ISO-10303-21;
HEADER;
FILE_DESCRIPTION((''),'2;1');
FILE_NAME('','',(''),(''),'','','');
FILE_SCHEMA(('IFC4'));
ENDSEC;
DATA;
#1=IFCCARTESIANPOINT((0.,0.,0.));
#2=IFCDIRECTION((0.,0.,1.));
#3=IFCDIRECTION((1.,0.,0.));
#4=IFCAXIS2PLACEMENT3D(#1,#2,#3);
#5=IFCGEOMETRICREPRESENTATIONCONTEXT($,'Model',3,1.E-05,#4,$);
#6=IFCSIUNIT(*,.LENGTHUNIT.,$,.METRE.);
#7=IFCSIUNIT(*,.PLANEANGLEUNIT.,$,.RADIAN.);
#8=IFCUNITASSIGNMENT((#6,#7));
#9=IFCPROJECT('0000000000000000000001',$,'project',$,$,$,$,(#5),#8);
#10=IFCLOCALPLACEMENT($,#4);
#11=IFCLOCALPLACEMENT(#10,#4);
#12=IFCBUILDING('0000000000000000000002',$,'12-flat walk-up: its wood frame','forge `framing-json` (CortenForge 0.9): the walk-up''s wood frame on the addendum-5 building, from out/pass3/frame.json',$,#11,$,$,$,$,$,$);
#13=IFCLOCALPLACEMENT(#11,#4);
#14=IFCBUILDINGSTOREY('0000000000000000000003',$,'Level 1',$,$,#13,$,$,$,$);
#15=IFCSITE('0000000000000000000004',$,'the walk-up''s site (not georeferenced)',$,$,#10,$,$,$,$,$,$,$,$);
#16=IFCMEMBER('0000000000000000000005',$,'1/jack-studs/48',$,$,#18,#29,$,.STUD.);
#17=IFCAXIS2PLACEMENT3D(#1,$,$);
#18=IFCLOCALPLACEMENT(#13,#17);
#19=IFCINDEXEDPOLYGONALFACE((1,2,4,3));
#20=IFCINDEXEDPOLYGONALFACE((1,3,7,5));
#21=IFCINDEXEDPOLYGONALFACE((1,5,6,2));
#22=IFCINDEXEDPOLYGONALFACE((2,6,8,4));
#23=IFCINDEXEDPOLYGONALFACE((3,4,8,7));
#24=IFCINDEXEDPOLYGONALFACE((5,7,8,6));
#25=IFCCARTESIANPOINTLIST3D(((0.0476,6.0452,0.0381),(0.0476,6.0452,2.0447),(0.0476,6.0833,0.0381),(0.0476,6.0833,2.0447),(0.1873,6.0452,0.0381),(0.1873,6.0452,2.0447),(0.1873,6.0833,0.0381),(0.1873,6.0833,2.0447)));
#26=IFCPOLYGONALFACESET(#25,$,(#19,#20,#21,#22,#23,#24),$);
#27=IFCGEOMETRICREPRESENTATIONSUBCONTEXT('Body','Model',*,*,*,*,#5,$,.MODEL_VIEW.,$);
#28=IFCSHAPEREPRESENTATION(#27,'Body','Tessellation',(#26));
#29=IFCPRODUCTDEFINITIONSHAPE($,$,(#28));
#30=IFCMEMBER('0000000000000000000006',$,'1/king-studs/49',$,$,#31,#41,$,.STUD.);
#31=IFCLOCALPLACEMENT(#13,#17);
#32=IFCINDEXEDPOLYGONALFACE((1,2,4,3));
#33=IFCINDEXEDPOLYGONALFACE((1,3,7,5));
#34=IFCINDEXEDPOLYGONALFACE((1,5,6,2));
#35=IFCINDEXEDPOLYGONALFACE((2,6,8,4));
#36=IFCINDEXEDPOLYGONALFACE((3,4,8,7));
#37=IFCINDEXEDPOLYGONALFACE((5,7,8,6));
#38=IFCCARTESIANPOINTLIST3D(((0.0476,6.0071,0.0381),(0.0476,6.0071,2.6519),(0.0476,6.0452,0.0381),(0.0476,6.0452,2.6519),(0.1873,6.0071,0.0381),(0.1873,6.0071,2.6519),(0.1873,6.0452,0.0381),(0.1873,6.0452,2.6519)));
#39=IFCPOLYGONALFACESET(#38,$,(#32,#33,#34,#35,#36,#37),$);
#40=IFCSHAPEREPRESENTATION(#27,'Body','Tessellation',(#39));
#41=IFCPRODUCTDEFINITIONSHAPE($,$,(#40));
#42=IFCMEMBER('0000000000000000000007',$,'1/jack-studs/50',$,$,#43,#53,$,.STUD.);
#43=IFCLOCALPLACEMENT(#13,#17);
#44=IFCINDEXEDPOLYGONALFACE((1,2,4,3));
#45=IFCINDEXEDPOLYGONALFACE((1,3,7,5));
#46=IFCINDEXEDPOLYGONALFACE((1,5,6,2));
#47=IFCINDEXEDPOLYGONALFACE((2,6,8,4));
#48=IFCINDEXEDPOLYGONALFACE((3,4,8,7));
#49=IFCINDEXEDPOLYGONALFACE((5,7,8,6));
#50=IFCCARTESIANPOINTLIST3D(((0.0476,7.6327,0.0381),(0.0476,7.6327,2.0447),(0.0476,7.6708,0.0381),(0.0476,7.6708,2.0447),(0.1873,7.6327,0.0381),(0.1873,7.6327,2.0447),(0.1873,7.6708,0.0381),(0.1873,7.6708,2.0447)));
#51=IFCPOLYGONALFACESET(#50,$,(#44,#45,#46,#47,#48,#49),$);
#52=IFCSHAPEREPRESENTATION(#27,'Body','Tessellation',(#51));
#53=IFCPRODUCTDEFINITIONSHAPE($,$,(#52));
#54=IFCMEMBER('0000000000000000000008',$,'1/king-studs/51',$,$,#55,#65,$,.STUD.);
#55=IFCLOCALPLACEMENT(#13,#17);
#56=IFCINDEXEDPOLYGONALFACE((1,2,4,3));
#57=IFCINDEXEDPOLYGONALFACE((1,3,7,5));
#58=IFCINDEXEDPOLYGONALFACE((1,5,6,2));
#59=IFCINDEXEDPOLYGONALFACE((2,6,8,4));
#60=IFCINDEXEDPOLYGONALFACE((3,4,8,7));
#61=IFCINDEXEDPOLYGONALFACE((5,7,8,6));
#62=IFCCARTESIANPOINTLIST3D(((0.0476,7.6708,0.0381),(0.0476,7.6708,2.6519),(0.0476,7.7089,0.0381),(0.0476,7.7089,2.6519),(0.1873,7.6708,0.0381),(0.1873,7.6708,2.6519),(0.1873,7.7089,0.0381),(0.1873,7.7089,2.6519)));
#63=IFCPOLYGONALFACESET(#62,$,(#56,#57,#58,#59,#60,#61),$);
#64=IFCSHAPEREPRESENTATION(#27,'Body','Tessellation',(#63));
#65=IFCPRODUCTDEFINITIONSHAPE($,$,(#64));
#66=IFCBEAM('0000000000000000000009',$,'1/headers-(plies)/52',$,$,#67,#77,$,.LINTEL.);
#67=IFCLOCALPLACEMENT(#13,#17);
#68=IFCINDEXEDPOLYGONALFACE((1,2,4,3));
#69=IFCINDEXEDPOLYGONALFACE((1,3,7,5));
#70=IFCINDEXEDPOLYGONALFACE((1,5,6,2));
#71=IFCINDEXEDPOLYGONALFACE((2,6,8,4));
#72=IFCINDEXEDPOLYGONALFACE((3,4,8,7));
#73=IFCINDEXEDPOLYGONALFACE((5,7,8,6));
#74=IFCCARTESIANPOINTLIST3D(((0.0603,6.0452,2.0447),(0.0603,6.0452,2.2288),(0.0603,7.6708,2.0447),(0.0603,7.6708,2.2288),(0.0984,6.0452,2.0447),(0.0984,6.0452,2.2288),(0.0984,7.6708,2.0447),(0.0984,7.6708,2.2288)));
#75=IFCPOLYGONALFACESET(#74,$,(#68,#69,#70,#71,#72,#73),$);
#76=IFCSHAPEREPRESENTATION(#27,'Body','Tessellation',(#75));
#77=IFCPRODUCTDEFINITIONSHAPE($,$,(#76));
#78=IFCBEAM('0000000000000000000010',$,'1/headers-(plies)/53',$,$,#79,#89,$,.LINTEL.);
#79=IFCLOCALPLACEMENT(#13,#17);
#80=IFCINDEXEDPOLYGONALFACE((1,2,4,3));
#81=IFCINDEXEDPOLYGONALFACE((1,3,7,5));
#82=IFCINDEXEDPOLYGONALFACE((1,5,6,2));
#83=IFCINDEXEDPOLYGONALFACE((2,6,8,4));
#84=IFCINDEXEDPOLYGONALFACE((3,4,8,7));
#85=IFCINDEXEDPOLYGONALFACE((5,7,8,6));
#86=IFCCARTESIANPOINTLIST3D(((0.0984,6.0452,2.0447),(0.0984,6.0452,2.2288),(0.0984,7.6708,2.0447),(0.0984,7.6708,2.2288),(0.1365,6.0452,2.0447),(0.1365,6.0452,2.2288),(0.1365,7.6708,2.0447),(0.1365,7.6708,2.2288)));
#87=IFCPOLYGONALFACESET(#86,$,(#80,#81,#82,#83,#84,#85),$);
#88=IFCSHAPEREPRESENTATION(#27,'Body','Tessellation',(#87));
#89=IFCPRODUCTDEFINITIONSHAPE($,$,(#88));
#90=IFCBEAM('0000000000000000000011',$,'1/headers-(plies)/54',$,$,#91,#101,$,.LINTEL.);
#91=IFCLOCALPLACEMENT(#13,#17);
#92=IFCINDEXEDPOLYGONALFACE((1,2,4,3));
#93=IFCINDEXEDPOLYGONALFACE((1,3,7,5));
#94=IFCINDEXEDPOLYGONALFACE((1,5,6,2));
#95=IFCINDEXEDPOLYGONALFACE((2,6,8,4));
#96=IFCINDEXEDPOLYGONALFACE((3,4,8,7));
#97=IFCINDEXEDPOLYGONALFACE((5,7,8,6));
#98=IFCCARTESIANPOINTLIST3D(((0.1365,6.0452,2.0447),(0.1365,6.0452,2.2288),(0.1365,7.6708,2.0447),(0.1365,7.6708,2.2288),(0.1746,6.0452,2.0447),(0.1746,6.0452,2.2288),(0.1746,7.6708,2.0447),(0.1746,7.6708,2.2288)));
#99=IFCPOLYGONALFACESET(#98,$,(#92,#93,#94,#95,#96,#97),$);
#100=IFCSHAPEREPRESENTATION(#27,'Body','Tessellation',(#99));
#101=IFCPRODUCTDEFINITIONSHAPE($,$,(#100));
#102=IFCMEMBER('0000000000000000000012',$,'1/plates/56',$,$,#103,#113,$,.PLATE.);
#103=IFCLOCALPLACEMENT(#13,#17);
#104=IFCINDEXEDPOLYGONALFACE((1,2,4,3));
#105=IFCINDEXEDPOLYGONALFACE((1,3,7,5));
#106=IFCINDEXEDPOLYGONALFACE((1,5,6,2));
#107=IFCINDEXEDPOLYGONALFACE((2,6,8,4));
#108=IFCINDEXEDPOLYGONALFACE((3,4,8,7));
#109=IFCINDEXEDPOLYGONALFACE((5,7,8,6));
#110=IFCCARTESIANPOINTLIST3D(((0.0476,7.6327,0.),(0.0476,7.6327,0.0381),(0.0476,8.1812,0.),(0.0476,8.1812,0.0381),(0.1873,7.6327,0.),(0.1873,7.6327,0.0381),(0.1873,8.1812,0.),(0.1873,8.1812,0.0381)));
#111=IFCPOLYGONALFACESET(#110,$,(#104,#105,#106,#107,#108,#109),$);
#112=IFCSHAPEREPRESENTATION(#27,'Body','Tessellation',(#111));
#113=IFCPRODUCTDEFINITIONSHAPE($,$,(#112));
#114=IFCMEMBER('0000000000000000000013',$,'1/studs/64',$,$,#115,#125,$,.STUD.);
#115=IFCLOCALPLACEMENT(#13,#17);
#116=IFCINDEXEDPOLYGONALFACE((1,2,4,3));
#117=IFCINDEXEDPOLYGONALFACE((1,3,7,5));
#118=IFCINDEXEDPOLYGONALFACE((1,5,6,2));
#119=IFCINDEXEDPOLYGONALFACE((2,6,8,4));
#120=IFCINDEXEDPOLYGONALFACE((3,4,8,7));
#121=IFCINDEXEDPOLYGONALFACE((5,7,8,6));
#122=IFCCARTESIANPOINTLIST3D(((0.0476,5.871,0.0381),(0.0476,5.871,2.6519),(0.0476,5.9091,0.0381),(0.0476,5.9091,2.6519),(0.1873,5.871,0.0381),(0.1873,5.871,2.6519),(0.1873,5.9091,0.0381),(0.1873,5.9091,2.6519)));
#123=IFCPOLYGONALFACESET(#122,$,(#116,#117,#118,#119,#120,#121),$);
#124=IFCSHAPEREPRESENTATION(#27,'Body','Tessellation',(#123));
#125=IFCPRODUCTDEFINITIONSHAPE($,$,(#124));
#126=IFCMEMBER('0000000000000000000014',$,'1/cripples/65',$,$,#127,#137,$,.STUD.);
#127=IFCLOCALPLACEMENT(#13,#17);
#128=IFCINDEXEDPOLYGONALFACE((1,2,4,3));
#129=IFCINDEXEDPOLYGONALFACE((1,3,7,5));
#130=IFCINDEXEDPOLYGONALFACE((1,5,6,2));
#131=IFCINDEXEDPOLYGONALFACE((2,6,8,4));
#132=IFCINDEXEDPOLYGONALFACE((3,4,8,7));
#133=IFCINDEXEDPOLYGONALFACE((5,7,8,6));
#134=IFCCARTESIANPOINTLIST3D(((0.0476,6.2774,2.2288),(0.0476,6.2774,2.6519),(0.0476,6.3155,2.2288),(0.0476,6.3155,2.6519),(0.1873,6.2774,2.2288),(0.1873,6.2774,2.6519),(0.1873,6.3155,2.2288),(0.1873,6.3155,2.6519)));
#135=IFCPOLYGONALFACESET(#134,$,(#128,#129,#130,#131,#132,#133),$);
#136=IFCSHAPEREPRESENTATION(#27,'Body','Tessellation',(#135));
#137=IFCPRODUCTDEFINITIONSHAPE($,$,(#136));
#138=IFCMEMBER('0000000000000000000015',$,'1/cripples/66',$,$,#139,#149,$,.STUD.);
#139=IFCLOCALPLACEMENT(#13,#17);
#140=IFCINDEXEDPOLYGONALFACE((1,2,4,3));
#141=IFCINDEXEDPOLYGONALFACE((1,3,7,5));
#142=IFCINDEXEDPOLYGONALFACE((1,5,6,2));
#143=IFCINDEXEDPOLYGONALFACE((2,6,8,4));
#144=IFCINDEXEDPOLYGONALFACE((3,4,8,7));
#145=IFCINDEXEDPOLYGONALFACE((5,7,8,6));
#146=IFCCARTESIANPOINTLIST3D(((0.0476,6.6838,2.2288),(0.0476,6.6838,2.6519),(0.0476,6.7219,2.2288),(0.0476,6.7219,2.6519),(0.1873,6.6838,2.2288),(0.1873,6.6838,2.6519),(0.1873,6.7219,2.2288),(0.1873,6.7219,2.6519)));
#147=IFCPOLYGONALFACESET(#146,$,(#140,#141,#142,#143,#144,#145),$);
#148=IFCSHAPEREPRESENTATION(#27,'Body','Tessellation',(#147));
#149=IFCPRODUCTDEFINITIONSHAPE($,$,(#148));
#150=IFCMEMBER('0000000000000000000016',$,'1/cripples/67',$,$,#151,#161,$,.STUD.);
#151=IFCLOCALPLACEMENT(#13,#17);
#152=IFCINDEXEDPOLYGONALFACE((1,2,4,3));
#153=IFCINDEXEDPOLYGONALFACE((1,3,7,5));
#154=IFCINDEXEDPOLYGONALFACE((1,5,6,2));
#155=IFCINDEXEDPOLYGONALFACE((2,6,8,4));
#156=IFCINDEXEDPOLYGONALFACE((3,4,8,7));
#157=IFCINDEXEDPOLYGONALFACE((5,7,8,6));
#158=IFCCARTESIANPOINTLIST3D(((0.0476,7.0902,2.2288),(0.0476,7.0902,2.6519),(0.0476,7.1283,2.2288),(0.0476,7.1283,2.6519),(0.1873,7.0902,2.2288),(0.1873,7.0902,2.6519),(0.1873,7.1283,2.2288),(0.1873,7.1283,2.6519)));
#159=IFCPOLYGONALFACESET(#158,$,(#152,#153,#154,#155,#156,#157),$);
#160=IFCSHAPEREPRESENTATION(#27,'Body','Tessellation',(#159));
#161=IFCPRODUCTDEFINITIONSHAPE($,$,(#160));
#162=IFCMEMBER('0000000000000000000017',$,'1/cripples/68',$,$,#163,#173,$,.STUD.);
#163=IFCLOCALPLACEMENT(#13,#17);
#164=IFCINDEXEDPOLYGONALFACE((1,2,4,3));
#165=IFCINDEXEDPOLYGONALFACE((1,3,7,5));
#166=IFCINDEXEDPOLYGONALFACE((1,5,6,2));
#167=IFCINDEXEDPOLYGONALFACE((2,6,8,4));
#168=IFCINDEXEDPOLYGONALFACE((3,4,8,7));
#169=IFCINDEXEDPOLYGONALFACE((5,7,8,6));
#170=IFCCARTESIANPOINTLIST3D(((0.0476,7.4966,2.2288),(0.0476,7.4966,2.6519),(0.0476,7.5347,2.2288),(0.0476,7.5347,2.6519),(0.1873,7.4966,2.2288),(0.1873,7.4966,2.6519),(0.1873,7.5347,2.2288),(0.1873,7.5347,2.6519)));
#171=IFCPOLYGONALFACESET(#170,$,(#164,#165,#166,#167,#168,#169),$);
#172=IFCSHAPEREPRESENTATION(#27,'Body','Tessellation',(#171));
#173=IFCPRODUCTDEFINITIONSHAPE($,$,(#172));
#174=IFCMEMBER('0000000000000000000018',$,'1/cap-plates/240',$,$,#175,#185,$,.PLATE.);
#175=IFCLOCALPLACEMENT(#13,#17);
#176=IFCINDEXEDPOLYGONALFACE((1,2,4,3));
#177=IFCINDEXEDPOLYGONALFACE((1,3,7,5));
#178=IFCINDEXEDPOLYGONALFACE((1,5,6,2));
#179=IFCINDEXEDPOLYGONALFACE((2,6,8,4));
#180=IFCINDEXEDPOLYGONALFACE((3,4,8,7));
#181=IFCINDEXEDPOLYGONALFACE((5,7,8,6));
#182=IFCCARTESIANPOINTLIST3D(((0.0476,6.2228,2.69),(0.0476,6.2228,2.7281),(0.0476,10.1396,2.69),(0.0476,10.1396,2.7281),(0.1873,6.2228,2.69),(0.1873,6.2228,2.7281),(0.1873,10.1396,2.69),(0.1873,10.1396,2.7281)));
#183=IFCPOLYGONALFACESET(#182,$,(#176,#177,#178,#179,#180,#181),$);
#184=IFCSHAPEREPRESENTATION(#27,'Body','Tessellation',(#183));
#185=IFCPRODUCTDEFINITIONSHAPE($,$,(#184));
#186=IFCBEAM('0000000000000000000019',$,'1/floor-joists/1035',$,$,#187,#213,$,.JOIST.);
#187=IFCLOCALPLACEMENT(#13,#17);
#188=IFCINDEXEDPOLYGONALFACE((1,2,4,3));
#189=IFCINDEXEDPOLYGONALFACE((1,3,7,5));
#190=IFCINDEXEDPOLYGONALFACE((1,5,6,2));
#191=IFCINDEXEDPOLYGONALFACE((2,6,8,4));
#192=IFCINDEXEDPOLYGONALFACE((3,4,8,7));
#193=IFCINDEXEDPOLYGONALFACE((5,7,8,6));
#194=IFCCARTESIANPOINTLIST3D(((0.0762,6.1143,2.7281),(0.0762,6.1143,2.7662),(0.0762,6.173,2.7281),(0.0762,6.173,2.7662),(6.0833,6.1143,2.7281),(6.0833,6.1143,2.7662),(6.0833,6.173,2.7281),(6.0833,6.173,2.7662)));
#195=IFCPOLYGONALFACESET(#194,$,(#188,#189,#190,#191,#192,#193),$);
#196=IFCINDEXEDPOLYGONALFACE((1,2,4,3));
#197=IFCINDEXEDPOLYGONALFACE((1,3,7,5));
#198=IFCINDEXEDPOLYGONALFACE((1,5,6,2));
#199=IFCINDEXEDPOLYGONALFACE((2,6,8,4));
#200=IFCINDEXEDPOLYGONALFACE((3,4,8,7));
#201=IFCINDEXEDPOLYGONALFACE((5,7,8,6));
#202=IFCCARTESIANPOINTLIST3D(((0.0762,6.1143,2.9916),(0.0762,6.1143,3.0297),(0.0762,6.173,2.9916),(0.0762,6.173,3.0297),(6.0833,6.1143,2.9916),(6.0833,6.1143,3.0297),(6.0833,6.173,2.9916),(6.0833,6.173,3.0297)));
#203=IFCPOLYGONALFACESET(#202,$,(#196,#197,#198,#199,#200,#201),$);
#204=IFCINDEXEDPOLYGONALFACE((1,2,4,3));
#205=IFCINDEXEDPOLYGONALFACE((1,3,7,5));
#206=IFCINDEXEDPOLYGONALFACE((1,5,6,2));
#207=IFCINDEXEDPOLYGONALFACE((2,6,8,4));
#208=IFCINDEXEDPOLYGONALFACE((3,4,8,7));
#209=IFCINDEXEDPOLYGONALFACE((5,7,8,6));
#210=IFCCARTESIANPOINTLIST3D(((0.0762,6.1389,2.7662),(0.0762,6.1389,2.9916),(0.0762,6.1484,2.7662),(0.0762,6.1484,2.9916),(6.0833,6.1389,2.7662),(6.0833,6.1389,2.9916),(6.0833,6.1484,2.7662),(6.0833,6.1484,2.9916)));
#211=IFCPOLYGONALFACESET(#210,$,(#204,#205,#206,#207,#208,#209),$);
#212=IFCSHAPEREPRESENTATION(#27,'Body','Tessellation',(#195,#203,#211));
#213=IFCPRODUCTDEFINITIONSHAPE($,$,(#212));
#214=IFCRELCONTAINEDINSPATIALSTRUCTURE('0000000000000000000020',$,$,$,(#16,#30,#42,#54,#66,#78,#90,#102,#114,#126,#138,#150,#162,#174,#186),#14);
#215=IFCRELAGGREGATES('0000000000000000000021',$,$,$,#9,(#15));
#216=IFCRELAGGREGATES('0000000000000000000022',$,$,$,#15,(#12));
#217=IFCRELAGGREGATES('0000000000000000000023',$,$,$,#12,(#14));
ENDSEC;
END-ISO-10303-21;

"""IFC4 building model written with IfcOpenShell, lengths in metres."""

from ifc_helpers import new_model, si_unit, frame, frame_2d, origin, origin_with_axes, place, context, subcontext, project, spatial, rectangle, extrude, element, save


model = new_model("IFC4")

# Units and contexts
model_context = context("Model", 3, precision=1e-05, world=origin_with_axes())
body_context = subcontext(model_context, "Body", "Model", "MODEL_VIEW")
ifc_project = project(units=[si_unit("LENGTHUNIT", "METRE"), si_unit("PLANEANGLEUNIT", "RADIAN")], contexts=[model_context])

# Site, building, storey
site_placement = place(None, origin_with_axes())
site = spatial("IfcSite", under=ifc_project, at=site_placement, Name="the walk-up's site (not georeferenced)")
building_placement = place(site_placement, origin_with_axes())
building = spatial("IfcBuilding", under=site, at=building_placement, Name="12-flat walk-up: its wood frame", Description="forge `framing-json` (CortenForge 0.9): the walk-up's wood frame on the addendum-5 building, from out/pass3/frame.json")
storey_placement = place(building_placement, origin_with_axes())
storey = spatial("IfcBuildingStorey", under=building, at=storey_placement, Name="Level 1")

# Members
member_1_placement = place(storey_placement, frame((0.0476, 6.0452, 0.0381), z_axis=(0.0, 0.0, 1.0), x_axis=(1.0, 0.0, 0.0)))
element("IfcMember", 1, at=member_1_placement, inside=storey, Name="1/jack-studs/48", PredefinedType="STUD", context=body_context, shape_type="SweptSolid", body=[
    extrude(rectangle(XDim=0.1397, YDim=0.0381, at=frame_2d((0.0698, 0.0191))), origin(), (0.0, 0.0, 1.0), 2.0066),
])
member_2_placement = place(storey_placement, frame((0.0476, 6.0071, 0.0381), z_axis=(0.0, 0.0, 1.0), x_axis=(1.0, 0.0, 0.0)))
element("IfcMember", 2, at=member_2_placement, inside=storey, Name="1/king-studs/49", PredefinedType="STUD", context=body_context, shape_type="SweptSolid", body=[
    extrude(rectangle(XDim=0.1397, YDim=0.0381, at=frame_2d((0.0698, 0.0191))), origin(), (0.0, 0.0, 1.0), 2.6138),
])
member_3_placement = place(storey_placement, frame((0.0476, 7.6327, 0.0381), z_axis=(0.0, 0.0, 1.0), x_axis=(1.0, 0.0, 0.0)))
element("IfcMember", 3, at=member_3_placement, inside=storey, Name="1/jack-studs/50", PredefinedType="STUD", context=body_context, shape_type="SweptSolid", body=[
    extrude(rectangle(XDim=0.1397, YDim=0.0381, at=frame_2d((0.0698, 0.0191))), origin(), (0.0, 0.0, 1.0), 2.0066),
])
member_4_placement = place(storey_placement, frame((0.0476, 7.6708, 0.0381), z_axis=(0.0, 0.0, 1.0), x_axis=(1.0, 0.0, 0.0)))
element("IfcMember", 4, at=member_4_placement, inside=storey, Name="1/king-studs/51", PredefinedType="STUD", context=body_context, shape_type="SweptSolid", body=[
    extrude(rectangle(XDim=0.1397, YDim=0.0381, at=frame_2d((0.0698, 0.0191))), origin(), (0.0, 0.0, 1.0), 2.6138),
])

# Beams
beam_1_placement = place(storey_placement, frame((0.0603, 6.0452, 2.0447), z_axis=(0.0, 0.0, 1.0), x_axis=(1.0, 0.0, 0.0)))
element("IfcBeam", 5, at=beam_1_placement, inside=storey, Name="1/headers-(plies)/52", PredefinedType="LINTEL", context=body_context, shape_type="SweptSolid", body=[
    extrude(rectangle(XDim=0.0381, YDim=1.6256, at=frame_2d((0.0191, 0.8128))), origin(), (0.0, 0.0, 1.0), 0.1841),
])
beam_2_placement = place(storey_placement, frame((0.0984, 6.0452, 2.0447), z_axis=(0.0, 0.0, 1.0), x_axis=(1.0, 0.0, 0.0)))
element("IfcBeam", 6, at=beam_2_placement, inside=storey, Name="1/headers-(plies)/53", PredefinedType="LINTEL", context=body_context, shape_type="SweptSolid", body=[
    extrude(rectangle(XDim=0.0381, YDim=1.6256, at=frame_2d((0.0191, 0.8128))), origin(), (0.0, 0.0, 1.0), 0.1841),
])
beam_3_placement = place(storey_placement, frame((0.1365, 6.0452, 2.0447), z_axis=(0.0, 0.0, 1.0), x_axis=(1.0, 0.0, 0.0)))
element("IfcBeam", 7, at=beam_3_placement, inside=storey, Name="1/headers-(plies)/54", PredefinedType="LINTEL", context=body_context, shape_type="SweptSolid", body=[
    extrude(rectangle(XDim=0.0381, YDim=1.6256, at=frame_2d((0.019, 0.8128))), origin(), (0.0, 0.0, 1.0), 0.1841),
])

# Members
member_5_placement = place(storey_placement, frame((0.0476, 7.6327, 0.0), z_axis=(0.0, 0.0, 1.0), x_axis=(1.0, 0.0, 0.0)))
element("IfcMember", 8, at=member_5_placement, inside=storey, Name="1/plates/56", PredefinedType="PLATE", context=body_context, shape_type="SweptSolid", body=[
    extrude(rectangle(XDim=0.1397, YDim=0.5485, at=frame_2d((0.0698, 0.2743))), origin(), (0.0, 0.0, 1.0), 0.0381),
])
member_6_placement = place(storey_placement, frame((0.0476, 5.871, 0.0381), z_axis=(0.0, 0.0, 1.0), x_axis=(1.0, 0.0, 0.0)))
element("IfcMember", 9, at=member_6_placement, inside=storey, Name="1/studs/64", PredefinedType="STUD", context=body_context, shape_type="SweptSolid", body=[
    extrude(rectangle(XDim=0.1397, YDim=0.0381, at=frame_2d((0.0698, 0.0191))), origin(), (0.0, 0.0, 1.0), 2.6138),
])
for number, where, z_axis, x_axis, name in (
    (10, (0.0476, 6.2774, 2.2288), (0.0, 0.0, 1.0), (1.0, 0.0, 0.0), "1/cripples/65"),
    (11, (0.0476, 6.6838, 2.2288), (0.0, 0.0, 1.0), (1.0, 0.0, 0.0), "1/cripples/66"),
    (12, (0.0476, 7.0902, 2.2288), (0.0, 0.0, 1.0), (1.0, 0.0, 0.0), "1/cripples/67"),
    (13, (0.0476, 7.4966, 2.2288), (0.0, 0.0, 1.0), (1.0, 0.0, 0.0), "1/cripples/68"),
):
    element("IfcMember", number, at=place(storey_placement, frame(where, z_axis=z_axis, x_axis=x_axis)), inside=storey, Name=name, PredefinedType="STUD", context=body_context, shape_type="SweptSolid", body=[
        extrude(rectangle(XDim=0.1397, YDim=0.0381, at=frame_2d((0.0698, 0.0191))), origin(), (0.0, 0.0, 1.0), 0.4231),
    ])
member_7_placement = place(storey_placement, frame((0.0476, 6.2228, 2.69), z_axis=(0.0, 0.0, 1.0), x_axis=(1.0, 0.0, 0.0)))
element("IfcMember", 14, at=member_7_placement, inside=storey, Name="1/cap-plates/240", PredefinedType="PLATE", context=body_context, shape_type="SweptSolid", body=[
    extrude(rectangle(XDim=0.1397, YDim=3.9168, at=frame_2d((0.0698, 1.9584))), origin(), (0.0, 0.0, 1.0), 0.0381),
])

# Beam
beam_4_placement = place(storey_placement, frame((0.0762, 6.1143, 2.7281), z_axis=(0.0, 0.0, 1.0), x_axis=(1.0, 0.0, 0.0)))
element("IfcBeam", 15, at=beam_4_placement, inside=storey, Name="1/floor-joists/1035", PredefinedType="JOIST", context=body_context, shape_type="SweptSolid", body=[
    extrude(rectangle(XDim=6.0071, YDim=0.0587, at=frame_2d((3.0036, 0.0294))), origin(), (0.0, 0.0, 1.0), 0.0381),
    extrude(rectangle(XDim=6.0071, YDim=0.0587, at=frame_2d((3.0036, 0.0294))), frame((0.0, 0.0, 0.2635)), (0.0, 0.0, 1.0), 0.0381),
    extrude(rectangle(XDim=6.0071, YDim=0.0095, at=frame_2d((3.0036, 0.0048))), frame((0.0, 0.0246, 0.0381)), (0.0, 0.0, 1.0), 0.2254),
])

save(model, "model.ifc")
